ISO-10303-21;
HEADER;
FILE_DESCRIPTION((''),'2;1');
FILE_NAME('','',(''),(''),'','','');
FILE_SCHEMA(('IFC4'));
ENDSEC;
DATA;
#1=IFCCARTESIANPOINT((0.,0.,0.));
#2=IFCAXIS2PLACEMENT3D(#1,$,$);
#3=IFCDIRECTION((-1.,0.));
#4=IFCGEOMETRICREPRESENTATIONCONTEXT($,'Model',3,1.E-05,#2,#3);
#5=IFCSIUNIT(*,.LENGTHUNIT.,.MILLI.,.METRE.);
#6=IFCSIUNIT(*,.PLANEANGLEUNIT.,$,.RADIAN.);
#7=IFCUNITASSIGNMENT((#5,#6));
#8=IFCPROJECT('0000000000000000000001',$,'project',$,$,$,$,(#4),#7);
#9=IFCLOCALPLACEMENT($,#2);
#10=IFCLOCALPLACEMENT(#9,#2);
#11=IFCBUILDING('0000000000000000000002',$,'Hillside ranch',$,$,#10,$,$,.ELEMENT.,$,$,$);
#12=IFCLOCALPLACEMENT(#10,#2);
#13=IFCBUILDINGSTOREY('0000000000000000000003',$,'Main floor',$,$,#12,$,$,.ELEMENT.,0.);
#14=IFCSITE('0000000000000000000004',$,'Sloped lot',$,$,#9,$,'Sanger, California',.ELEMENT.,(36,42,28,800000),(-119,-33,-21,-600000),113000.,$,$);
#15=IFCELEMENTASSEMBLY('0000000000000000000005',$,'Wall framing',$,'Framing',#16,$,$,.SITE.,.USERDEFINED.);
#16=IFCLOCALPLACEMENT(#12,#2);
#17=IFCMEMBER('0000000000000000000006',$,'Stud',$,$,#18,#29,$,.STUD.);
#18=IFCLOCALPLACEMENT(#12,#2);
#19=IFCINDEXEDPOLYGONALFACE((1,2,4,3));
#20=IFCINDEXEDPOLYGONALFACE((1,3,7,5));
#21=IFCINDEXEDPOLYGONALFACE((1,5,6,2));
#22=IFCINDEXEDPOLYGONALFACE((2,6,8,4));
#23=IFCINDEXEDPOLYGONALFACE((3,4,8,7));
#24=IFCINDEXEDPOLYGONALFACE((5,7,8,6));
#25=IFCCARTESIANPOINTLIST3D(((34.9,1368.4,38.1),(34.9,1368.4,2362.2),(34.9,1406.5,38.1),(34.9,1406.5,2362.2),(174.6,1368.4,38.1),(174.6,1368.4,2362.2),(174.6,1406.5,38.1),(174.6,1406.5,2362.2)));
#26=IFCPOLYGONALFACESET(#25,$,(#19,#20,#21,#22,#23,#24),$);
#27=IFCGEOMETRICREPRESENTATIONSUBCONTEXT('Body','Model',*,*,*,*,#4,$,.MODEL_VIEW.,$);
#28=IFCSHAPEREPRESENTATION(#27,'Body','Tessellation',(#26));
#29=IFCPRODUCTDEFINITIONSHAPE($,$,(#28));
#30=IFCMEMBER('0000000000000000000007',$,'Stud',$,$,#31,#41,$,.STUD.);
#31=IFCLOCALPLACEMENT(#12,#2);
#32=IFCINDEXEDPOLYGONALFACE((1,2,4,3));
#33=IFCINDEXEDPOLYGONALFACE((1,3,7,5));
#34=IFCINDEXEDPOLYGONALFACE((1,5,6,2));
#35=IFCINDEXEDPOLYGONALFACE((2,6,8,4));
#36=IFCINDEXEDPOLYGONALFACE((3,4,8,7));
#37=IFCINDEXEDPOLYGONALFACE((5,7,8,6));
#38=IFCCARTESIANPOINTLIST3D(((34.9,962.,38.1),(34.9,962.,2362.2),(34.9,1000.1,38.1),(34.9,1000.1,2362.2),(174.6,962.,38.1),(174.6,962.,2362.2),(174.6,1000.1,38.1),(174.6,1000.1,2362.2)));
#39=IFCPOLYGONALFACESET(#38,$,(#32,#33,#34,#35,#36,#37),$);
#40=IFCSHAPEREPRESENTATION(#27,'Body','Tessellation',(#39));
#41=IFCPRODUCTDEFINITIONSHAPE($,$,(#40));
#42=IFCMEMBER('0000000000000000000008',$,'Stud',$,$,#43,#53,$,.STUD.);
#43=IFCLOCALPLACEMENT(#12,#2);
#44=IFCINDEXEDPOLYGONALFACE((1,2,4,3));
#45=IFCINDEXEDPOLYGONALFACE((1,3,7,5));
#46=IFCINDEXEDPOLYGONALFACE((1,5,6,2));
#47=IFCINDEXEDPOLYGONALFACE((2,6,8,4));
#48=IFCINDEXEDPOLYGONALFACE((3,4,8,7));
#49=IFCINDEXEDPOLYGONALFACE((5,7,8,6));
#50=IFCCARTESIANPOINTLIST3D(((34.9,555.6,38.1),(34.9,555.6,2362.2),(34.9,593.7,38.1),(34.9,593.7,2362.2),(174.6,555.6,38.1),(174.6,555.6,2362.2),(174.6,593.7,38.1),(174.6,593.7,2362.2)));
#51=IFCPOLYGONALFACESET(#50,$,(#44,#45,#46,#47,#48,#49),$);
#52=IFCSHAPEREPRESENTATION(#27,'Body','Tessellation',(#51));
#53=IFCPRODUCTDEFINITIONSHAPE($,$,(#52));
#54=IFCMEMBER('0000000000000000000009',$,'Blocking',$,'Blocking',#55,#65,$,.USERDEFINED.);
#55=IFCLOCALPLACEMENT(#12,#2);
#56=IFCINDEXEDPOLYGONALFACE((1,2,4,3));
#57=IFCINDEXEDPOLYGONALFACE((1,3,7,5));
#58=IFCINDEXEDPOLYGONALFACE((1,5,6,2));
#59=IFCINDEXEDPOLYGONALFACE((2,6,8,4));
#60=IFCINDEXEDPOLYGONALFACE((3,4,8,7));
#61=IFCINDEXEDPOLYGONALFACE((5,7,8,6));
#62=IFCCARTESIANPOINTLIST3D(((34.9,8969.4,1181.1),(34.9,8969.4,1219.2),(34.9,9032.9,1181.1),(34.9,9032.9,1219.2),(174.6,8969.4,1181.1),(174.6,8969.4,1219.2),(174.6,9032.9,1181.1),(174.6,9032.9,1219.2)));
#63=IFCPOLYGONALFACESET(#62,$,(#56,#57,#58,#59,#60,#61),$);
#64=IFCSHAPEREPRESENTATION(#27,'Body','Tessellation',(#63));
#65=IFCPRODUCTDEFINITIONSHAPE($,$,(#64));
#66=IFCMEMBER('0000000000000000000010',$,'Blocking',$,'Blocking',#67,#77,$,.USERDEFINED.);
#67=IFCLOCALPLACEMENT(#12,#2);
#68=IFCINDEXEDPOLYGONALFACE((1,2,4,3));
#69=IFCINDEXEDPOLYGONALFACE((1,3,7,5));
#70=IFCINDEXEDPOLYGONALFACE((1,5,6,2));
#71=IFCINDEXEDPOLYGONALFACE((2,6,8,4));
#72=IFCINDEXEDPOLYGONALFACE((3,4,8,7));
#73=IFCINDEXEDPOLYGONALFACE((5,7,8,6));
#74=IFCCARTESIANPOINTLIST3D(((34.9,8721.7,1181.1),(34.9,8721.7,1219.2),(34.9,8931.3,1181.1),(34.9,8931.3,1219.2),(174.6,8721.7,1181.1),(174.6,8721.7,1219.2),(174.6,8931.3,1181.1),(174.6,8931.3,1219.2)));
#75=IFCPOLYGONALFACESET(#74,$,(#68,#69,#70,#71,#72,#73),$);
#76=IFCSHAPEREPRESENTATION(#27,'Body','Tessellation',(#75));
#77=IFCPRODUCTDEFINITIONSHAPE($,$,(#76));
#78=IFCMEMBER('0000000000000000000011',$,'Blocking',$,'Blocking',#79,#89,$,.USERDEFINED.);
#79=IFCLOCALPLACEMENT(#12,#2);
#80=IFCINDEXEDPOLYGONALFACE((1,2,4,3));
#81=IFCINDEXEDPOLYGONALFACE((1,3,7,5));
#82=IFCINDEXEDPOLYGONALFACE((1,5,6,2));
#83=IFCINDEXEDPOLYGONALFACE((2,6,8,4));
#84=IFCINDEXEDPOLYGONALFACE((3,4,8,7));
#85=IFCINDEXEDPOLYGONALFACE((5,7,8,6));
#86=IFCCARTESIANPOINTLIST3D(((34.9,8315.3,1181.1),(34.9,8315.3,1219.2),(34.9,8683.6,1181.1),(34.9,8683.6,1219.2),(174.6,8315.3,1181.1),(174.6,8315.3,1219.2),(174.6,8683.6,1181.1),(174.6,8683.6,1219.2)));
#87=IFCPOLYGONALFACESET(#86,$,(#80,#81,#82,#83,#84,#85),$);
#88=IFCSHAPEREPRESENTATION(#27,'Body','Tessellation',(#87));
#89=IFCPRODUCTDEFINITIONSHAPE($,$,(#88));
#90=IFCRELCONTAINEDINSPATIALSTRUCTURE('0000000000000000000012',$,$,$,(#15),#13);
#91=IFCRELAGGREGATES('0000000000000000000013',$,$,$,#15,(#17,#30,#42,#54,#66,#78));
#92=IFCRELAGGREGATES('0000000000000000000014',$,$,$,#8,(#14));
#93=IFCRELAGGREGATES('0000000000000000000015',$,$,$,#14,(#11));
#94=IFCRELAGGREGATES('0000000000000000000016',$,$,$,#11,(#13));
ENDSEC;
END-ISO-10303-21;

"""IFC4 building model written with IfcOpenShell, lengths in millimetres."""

from ifc_helpers import new_model, si_unit, direction, frame, origin, origin_with_axes, place, context, subcontext, project, spatial, polyline, outline, extrude, element, aggregate, save


model = new_model("IFC4")

# Units and contexts
model_context = context("Model", 3, precision=1e-05, world=origin(), true_north=direction((-1.0, 0.0)))
body_context = subcontext(model_context, "Body", "Model", "MODEL_VIEW")
ifc_project = project(units=[si_unit("LENGTHUNIT", "METRE", prefix="MILLI"), si_unit("PLANEANGLEUNIT", "RADIAN")], contexts=[model_context])

# Site, building, storey
site_placement = place(None, origin())
site = spatial("IfcSite", under=ifc_project, at=site_placement, Name="Sloped lot", LongName="Sanger, California", CompositionType="ELEMENT", RefLatitude=(36, 42, 28, 800000), RefLongitude=(-119, -33, -21, -600000), RefElevation=113000.0)
building_placement = place(site_placement, origin())
building = spatial("IfcBuilding", under=site, at=building_placement, Name="Hillside ranch", CompositionType="ELEMENT")
storey_placement = place(building_placement, origin())
storey = spatial("IfcBuildingStorey", under=building, at=storey_placement, Name="Main floor", CompositionType="ELEMENT", Elevation=0.0)

# Element assembly, members
assembly_placement = place(storey_placement, origin_with_axes())
assembly = element("IfcElementAssembly", 1, at=assembly_placement, inside=storey, Name="Wall framing", ObjectType="Framing", AssemblyPlace="SITE", PredefinedType="USERDEFINED")
member_1_placement = place(storey_placement, origin_with_axes())
member_1 = element("IfcMember", 2, at=member_1_placement, Name="Stud", PredefinedType="STUD", context=body_context, shape_type="SweptSolid", body=[
    extrude(outline(polyline([(0.0, 0.0), (38.1, 0.0), (38.1, 139.7), (0.0, 139.7), (0.0, 0.0)])), frame((34.9, 1406.5, 38.1), z_axis=(0.0, 0.0, 1.0), x_axis=(0.0, -1.0, 0.0)), (0.0, 0.0, 1.0), 2324.1),
])
member_2_placement = place(storey_placement, origin_with_axes())
member_2 = element("IfcMember", 3, at=member_2_placement, Name="Stud", PredefinedType="STUD", context=body_context, shape_type="SweptSolid", body=[
    extrude(outline(polyline([(0.0, 0.0), (38.1, 0.0), (38.1, 139.7), (0.0, 139.7), (0.0, 0.0)])), frame((34.9, 1000.1, 38.1), z_axis=(0.0, 0.0, 1.0), x_axis=(0.0, -1.0, 0.0)), (0.0, 0.0, 1.0), 2324.1),
])
member_3_placement = place(storey_placement, origin_with_axes())
member_3 = element("IfcMember", 4, at=member_3_placement, Name="Stud", PredefinedType="STUD", context=body_context, shape_type="SweptSolid", body=[
    extrude(outline(polyline([(0.0, 0.0), (38.1, 0.0), (38.1, 139.7), (0.0, 139.7), (0.0, 0.0)])), frame((34.9, 593.7, 38.1), z_axis=(0.0, 0.0, 1.0), x_axis=(0.0, -1.0, 0.0)), (0.0, 0.0, 1.0), 2324.1),
])
member_4_placement = place(storey_placement, origin_with_axes())
member_4 = element("IfcMember", 5, at=member_4_placement, Name="Blocking", ObjectType="Blocking", PredefinedType="USERDEFINED", context=body_context, shape_type="SweptSolid", body=[
    extrude(outline(polyline([(0.0, 0.0), (63.5, 0.0), (63.5, 139.7), (0.0, 139.7), (0.0, 0.0)])), frame((34.9, 9032.9, 1181.1), z_axis=(0.0, 0.0, 1.0), x_axis=(0.0, -1.0, 0.0)), (0.0, 0.0, 1.0), 38.1),
])
member_5_placement = place(storey_placement, origin_with_axes())
member_5 = element("IfcMember", 6, at=member_5_placement, Name="Blocking", ObjectType="Blocking", PredefinedType="USERDEFINED", context=body_context, shape_type="SweptSolid", body=[
    extrude(outline(polyline([(0.0, 0.0), (209.6, 0.0), (209.6, 139.7), (0.0, 139.7), (0.0, 0.0)])), frame((34.9, 8931.3, 1181.1), z_axis=(0.0, 0.0, 1.0), x_axis=(0.0, -1.0, 0.0)), (0.0, 0.0, 1.0), 38.1),
])
member_6_placement = place(storey_placement, origin_with_axes())
member_6 = element("IfcMember", 7, at=member_6_placement, Name="Blocking", ObjectType="Blocking", PredefinedType="USERDEFINED", context=body_context, shape_type="SweptSolid", body=[
    extrude(outline(polyline([(0.0, 0.0), (368.3, 0.0), (368.3, 139.7), (0.0, 139.7), (0.0, 0.0)])), frame((34.9, 8683.6, 1181.1), z_axis=(0.0, 0.0, 1.0), x_axis=(0.0, -1.0, 0.0)), (0.0, 0.0, 1.0), 38.1),
])
aggregate(assembly, [member_1, member_2, member_3, member_4, member_5, member_6])

save(model, "model.ifc")
